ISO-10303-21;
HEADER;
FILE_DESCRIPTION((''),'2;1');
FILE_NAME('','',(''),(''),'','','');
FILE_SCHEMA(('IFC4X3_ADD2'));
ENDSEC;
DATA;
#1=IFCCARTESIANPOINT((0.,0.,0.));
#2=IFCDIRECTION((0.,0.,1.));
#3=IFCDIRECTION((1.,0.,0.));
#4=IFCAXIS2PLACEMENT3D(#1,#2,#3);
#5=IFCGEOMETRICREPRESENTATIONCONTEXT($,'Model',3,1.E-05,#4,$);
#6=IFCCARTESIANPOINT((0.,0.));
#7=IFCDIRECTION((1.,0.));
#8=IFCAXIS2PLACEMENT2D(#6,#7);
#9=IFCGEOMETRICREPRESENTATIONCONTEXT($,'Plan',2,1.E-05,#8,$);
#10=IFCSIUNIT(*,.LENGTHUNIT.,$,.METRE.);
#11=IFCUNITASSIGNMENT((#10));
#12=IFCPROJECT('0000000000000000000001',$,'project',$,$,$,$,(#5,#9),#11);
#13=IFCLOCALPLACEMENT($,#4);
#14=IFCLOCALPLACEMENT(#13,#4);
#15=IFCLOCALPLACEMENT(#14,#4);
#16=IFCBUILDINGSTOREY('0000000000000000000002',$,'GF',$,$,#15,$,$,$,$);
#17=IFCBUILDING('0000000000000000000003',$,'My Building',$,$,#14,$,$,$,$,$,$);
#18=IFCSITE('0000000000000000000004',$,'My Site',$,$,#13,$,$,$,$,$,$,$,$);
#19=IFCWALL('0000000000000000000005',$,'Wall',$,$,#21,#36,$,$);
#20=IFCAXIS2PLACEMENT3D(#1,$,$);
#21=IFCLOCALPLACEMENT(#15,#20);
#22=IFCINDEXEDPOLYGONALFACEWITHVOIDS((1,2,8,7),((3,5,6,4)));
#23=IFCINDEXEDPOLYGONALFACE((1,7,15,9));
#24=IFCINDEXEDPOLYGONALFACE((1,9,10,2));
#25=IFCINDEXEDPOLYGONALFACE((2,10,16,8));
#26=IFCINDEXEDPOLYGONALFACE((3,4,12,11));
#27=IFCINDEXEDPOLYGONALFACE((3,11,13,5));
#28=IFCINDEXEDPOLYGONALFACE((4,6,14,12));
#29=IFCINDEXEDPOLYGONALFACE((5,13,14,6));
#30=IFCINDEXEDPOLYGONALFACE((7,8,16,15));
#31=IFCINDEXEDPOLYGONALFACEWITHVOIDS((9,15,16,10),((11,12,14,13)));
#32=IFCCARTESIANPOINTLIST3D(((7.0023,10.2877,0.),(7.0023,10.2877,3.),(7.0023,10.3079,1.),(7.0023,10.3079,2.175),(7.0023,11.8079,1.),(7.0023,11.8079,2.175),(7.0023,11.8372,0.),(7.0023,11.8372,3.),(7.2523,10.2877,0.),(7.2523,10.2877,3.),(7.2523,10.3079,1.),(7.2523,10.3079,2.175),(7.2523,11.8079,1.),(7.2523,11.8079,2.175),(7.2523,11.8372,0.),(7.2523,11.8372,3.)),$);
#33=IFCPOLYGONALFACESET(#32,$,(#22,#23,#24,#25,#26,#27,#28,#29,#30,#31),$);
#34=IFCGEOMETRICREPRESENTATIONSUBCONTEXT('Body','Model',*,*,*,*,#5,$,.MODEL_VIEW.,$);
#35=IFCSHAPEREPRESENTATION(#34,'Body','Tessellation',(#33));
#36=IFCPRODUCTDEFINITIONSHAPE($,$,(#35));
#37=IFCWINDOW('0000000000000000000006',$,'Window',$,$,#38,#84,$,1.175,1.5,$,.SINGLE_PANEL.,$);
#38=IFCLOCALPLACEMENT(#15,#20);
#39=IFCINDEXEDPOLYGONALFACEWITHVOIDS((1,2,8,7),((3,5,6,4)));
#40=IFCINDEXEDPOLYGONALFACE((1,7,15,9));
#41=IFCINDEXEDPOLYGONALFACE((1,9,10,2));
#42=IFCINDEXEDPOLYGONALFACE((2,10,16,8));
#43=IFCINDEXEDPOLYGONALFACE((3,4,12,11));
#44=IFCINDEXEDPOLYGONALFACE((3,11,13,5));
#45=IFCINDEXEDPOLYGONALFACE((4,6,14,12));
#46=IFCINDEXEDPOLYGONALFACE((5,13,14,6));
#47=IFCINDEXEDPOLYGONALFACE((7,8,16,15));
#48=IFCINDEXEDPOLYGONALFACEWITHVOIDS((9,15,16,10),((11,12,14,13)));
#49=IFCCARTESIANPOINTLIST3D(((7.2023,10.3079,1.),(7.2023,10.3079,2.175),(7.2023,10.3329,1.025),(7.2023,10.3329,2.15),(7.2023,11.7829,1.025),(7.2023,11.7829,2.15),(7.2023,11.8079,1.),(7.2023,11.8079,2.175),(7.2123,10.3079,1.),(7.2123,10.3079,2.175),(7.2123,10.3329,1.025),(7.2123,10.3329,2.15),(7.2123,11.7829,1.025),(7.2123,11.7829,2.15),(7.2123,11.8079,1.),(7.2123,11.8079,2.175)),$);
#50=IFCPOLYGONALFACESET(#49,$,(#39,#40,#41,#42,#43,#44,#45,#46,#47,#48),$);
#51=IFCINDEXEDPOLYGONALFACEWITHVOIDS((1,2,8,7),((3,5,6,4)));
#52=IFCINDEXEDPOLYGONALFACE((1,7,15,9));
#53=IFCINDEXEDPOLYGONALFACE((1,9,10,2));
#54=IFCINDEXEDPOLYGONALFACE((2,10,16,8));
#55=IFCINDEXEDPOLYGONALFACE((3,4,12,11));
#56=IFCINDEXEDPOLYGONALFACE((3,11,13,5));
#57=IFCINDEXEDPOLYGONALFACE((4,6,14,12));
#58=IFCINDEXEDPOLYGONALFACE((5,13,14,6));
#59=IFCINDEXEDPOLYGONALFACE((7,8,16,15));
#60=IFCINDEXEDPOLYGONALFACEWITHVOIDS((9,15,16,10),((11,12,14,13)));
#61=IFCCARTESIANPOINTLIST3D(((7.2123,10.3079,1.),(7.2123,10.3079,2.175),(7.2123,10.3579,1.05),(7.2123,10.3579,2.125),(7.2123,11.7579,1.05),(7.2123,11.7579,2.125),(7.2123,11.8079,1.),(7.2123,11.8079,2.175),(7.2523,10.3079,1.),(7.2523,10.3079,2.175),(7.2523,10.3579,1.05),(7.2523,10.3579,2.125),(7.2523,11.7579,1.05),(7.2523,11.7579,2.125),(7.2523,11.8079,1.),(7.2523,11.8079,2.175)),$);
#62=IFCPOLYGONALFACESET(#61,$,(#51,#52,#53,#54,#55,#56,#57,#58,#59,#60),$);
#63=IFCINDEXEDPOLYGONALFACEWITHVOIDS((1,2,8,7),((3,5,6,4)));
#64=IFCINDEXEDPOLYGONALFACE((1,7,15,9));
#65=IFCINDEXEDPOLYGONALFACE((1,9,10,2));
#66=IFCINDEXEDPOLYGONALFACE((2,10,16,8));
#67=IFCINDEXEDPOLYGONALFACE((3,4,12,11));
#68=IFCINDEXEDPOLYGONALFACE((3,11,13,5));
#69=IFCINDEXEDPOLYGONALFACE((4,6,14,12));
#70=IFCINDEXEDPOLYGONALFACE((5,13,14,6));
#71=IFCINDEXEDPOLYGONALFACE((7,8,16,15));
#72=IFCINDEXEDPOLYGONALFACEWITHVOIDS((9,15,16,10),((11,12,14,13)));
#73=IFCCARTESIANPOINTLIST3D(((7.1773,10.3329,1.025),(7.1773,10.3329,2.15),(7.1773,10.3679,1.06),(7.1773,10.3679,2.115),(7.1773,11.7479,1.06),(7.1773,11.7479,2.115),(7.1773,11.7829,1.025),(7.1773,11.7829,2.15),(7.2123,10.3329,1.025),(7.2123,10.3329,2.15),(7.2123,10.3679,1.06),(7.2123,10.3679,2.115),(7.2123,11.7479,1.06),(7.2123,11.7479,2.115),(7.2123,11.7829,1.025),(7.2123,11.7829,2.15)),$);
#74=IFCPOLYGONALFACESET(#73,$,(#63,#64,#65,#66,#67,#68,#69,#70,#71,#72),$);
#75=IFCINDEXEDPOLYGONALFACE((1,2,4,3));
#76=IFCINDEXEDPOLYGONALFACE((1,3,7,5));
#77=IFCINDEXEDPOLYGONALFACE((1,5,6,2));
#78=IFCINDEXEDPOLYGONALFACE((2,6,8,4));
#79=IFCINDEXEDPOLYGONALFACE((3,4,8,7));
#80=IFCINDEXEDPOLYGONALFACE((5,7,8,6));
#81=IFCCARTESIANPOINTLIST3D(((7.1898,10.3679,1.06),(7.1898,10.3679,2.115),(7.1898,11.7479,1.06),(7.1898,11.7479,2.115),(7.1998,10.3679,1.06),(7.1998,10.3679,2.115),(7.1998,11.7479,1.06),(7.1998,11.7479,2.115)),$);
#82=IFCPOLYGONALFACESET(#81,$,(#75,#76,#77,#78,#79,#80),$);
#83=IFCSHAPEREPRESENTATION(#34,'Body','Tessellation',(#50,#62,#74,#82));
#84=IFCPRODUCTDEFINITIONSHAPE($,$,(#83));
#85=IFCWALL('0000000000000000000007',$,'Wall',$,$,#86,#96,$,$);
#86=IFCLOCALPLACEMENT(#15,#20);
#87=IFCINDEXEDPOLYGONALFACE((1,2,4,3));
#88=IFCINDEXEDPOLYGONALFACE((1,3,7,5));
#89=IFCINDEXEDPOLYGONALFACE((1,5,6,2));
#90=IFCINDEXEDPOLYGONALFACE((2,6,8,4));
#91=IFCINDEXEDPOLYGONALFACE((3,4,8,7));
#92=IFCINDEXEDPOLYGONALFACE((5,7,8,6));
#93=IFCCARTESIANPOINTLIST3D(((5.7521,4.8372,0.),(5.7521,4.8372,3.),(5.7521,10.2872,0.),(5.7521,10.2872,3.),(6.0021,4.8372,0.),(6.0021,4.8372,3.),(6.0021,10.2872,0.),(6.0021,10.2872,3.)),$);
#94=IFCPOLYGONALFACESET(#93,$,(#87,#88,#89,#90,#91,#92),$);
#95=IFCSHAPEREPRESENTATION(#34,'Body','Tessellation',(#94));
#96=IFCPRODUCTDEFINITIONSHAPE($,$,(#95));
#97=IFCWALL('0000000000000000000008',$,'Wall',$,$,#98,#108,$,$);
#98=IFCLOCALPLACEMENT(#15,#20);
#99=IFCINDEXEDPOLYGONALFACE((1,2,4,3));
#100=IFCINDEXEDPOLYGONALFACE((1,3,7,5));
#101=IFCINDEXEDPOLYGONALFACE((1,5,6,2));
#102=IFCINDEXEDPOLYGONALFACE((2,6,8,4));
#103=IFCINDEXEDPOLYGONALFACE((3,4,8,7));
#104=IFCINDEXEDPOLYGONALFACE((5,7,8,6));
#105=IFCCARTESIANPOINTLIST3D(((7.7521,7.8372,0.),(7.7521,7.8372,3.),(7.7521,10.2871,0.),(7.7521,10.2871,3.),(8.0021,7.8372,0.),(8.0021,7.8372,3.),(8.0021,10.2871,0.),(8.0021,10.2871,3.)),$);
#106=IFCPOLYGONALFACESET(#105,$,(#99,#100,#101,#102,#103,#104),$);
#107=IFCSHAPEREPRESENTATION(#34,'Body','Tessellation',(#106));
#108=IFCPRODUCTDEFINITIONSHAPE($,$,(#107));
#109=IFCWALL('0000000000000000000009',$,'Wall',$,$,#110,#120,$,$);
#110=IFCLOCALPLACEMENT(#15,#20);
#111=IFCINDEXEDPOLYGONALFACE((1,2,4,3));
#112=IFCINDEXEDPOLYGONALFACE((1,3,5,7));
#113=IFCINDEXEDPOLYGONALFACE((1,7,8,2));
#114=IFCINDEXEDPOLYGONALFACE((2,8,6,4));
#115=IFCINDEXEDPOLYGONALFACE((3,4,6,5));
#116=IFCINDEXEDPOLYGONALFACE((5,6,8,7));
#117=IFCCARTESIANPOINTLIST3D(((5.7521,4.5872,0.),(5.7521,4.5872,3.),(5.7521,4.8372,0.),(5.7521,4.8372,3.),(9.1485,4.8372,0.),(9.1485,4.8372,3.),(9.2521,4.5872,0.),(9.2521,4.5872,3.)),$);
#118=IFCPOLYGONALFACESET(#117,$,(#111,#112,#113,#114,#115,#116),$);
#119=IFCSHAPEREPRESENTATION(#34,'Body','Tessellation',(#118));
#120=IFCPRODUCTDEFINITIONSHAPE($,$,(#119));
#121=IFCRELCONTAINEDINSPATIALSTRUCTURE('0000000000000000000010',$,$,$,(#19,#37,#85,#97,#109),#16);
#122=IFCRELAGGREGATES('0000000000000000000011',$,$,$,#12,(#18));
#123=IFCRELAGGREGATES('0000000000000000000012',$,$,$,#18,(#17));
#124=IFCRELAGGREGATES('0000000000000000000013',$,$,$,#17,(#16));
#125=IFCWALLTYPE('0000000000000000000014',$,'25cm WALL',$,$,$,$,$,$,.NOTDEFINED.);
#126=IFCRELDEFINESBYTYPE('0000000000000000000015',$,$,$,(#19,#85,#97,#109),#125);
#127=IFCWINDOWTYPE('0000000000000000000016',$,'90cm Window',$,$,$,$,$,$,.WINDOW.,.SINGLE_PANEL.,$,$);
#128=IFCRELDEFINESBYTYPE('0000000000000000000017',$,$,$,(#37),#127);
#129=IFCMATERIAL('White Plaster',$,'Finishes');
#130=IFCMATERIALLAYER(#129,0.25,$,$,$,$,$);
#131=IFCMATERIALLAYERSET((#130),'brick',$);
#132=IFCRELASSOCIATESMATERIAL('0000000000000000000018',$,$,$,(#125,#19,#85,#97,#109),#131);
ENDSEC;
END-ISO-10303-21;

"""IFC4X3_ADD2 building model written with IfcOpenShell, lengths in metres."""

from ifc_helpers import new_model, entity, si_unit, frame, origin_with_axes, origin_2d_with_axis, place, context, subcontext, project, spatial, line, indexed_curve, outline, extrude, shape, source, transform, mapped, material, layer, layer_set, layer_usage, type_object, type_shapes, element, fill, save


model = new_model("IFC4X3_ADD2")

# Units and contexts
model_context = context("Model", 3, precision=1e-05, world=origin_with_axes())
plan_context = context("Plan", 2, precision=1e-05, world=origin_2d_with_axis())
body_context_1 = subcontext(model_context, "Body", "Model", "MODEL_VIEW")
body_context_2 = subcontext(plan_context, "Body", "Plan", "PLAN_VIEW")
ifc_project = project(units=[si_unit("LENGTHUNIT", "METRE")], contexts=[model_context, plan_context])

# Site, building, storey
site_placement = place(None, origin_with_axes())
site = spatial("IfcSite", under=ifc_project, at=site_placement, Name="My Site")
building_placement = place(site_placement, origin_with_axes())
building = spatial("IfcBuilding", under=site, at=building_placement, Name="My Building")
storey_placement = place(building_placement, origin_with_axes())
storey = spatial("IfcBuildingStorey", under=building, at=storey_placement, Name="GF")

# Shared definitions
ifc_material_1 = material(Name="White Plaster", Category="Finishes")

# Shared definitions
ifc_layer_1 = layer(ifc_material_1, 0.25)
ifc_layer_set_1 = layer_set([ifc_layer_1], Name="brick")
wall_type_1 = type_object("IfcWallType", Name="25cm WALL", PredefinedType="NOTDEFINED", material=ifc_layer_set_1)

# Wall, opening, window
ifc_layer_usage_1 = layer_usage(ifc_layer_set_1, "AXIS2", "POSITIVE", 0.0)
wall_1_placement = place(storey_placement, frame((7.0023, 11.8372, 0.0), z_axis=(0.0, 0.0, 1.0), x_axis=(0.0, -1.0, 0.0)))
wall_1 = element("IfcWall", 1, at=wall_1_placement, inside=storey, type_object=wall_type_1, material=ifc_layer_usage_1, Name="Wall", context=body_context_1, shape_type="SweptSolid", body=[
    extrude(outline(indexed_curve([(0.0, 0.0), (0.0, 0.25), (1.5495, 0.25), (1.5495, 0.0)], segments=[line(1, 2, 3, 4, 1)])), origin_with_axes(), (0.0, 0.0, 1.0), 3.0),
])
shared_shape_1 = source(origin_with_axes(), body_context_1, "Body", "SweptSolid", [
    extrude(outline(indexed_curve([(0.0, 0.0), (1.5, 0.0), (1.5, 1.175), (0.0, 1.175)], segments=[line(1, 2, 3, 4, 1)])), frame((0.0, -0.6, 0.0), z_axis=(0.0, -1.0, 0.0), x_axis=(1.0, 0.0, 0.0)), (0.0, 0.0, -1.0), 1.2),
])
opening_1_placement = place(wall_1_placement, frame((1.5293, 0.3, 1.0), z_axis=(0.0, 0.0, 1.0), x_axis=(-1.0, 0.0, 0.0)))
opening_1 = element("IfcOpeningElement", 2, at=opening_1_placement, cuts=wall_1, PredefinedType="OPENING", context=body_context_1, shape_type="MappedRepresentation", body=[
    mapped(shared_shape_1, transform((0.0, 0.0, 0.0), x_axis=(1.0, 0.0, 0.0), y_axis=(0.0, 1.0, 0.0), z_axis=(0.0, 0.0, 1.0), scale=1.0)),
])
window_type_1 = type_object("IfcWindowType", Name="90cm Window", PartitioningType="SINGLE_PANEL", PredefinedType="WINDOW")
shared_shape_2 = source(origin_with_axes(), body_context_1, "Body", "SweptSolid", [
    extrude(outline(indexed_curve([(0.0, 0.0), (1.5, 0.0), (1.5, 1.175), (0.0, 1.175)], segments=[line(1, 2, 3, 4, 1)]), holes=[indexed_curve([(0.025, 0.025), (1.475, 0.025), (1.475, 1.15), (0.025, 1.15)], segments=[line(1, 2, 3, 4, 1)])]), frame((0.0, 0.09, 0.0), z_axis=(0.0, -1.0, 0.0), x_axis=(1.0, 0.0, 0.0)), (0.0, 0.0, -1.0), 0.01),
    extrude(outline(indexed_curve([(0.0, 0.0), (1.5, 0.0), (1.5, 1.175), (0.0, 1.175)], segments=[line(1, 2, 3, 4, 1)]), holes=[indexed_curve([(0.05, 0.05), (1.45, 0.05), (1.45, 1.125), (0.05, 1.125)], segments=[line(1, 2, 3, 4, 1)])]), frame((0.0, 0.05, 0.0), z_axis=(0.0, -1.0, 0.0), x_axis=(1.0, 0.0, 0.0)), (0.0, 0.0, -1.0), 0.04),
    extrude(outline(indexed_curve([(0.0, 0.0), (1.45, 0.0), (1.45, 1.125), (0.0, 1.125)], segments=[line(1, 2, 3, 4, 1)]), holes=[indexed_curve([(0.035, 0.035), (1.415, 0.035), (1.415, 1.09), (0.035, 1.09)], segments=[line(1, 2, 3, 4, 1)])]), frame((0.025, 0.09, 0.025), z_axis=(0.0, -1.0, 0.0), x_axis=(1.0, 0.0, 0.0)), (0.0, 0.0, -1.0), 0.035),
    extrude(outline(indexed_curve([(0.035, 0.035), (1.415, 0.035), (1.415, 1.09), (0.035, 1.09)], segments=[line(1, 2, 3, 4, 1)])), frame((0.025, 0.1025, 0.025), z_axis=(0.0, -1.0, 0.0), x_axis=(1.0, 0.0, 0.0)), (0.0, 0.0, -1.0), 0.01),
])
shared_shape_3 = source(origin_with_axes(), body_context_2, "Body", "Curve2D", [
    entity("IfcIndexedPolyCurve", entity("IfcCartesianPointList2D", [[0.05, 0.05], [1.45, 0.05]])),
    entity("IfcIndexedPolyCurve", entity("IfcCartesianPointList2D", [[0.0, 0.1], [0.025, 0.1], [0.025, 0.09], [0.05, 0.09], [0.05, 0.05], [0.0, 0.05]]), [entity("IfcLineIndex", [1, 2, 3, 4, 5, 6, 1])]),
    entity("IfcIndexedPolyCurve", entity("IfcCartesianPointList2D", [[1.5, 0.1], [1.475, 0.1], [1.475, 0.09], [1.45, 0.09], [1.45, 0.05], [1.5, 0.05]]), [entity("IfcLineIndex", [1, 2, 3, 4, 5, 6, 1])]),
    entity("IfcIndexedPolyCurve", entity("IfcCartesianPointList2D", [[0.025, 0.09], [0.06, 0.09], [0.06, 0.125], [0.025, 0.125]]), [entity("IfcLineIndex", [1, 2, 3, 4, 1])]),
    entity("IfcIndexedPolyCurve", entity("IfcCartesianPointList2D", [[1.475, 0.09], [1.44, 0.09], [1.44, 0.125], [1.475, 0.125]]), [entity("IfcLineIndex", [1, 2, 3, 4, 1])]),
    entity("IfcIndexedPolyCurve", entity("IfcCartesianPointList2D", [[0.06, 0.09], [1.44, 0.09]])),
    entity("IfcIndexedPolyCurve", entity("IfcCartesianPointList2D", [[0.06, 0.125], [1.44, 0.125]])),
    entity("IfcIndexedPolyCurve", entity("IfcCartesianPointList2D", [[0.06, 0.1075], [1.44, 0.1075]])),
])
type_shapes(window_type_1, [shared_shape_2, shared_shape_3])
window_1_placement = place(opening_1_placement, origin_with_axes())
window_1 = element("IfcWindow", 3, at=window_1_placement, inside=storey, type_object=window_type_1, Name="Window", OverallHeight=1.175, OverallWidth=1.5, PartitioningType="SINGLE_PANEL", shapes=[
    shape(body_context_1, "Body", "MappedRepresentation", [mapped(shared_shape_2, transform((0.0, 0.0, 0.0), x_axis=(1.0, 0.0, 0.0), y_axis=(0.0, 1.0, 0.0), z_axis=(0.0, 0.0, 1.0), scale=1.0))]),
    shape(body_context_2, "Body", "MappedRepresentation", [mapped(shared_shape_3, transform((0.0, 0.0, 0.0), x_axis=(1.0, 0.0, 0.0), y_axis=(0.0, 1.0, 0.0), z_axis=(0.0, 0.0, 1.0), scale=1.0))]),
])
fill(opening_1, window_1)

# Walls
ifc_layer_usage_2 = layer_usage(ifc_layer_set_1, "AXIS2", "POSITIVE", 0.0)
wall_2_placement = place(storey_placement, frame((5.7521, 10.2872, 0.0), z_axis=(0.0, 0.0, 1.0), x_axis=(0.0, -1.0, 0.0)))
element("IfcWall", 4, at=wall_2_placement, inside=storey, type_object=wall_type_1, material=ifc_layer_usage_2, Name="Wall", context=body_context_1, shape_type="SweptSolid", body=[
    extrude(outline(indexed_curve([(0.0, 0.0), (0.0, 0.25), (5.45, 0.25), (5.45, 0.0)], segments=[line(1, 2, 3, 4, 1)])), origin_with_axes(), (0.0, 0.0, 1.0), 3.0),
])
ifc_layer_usage_3 = layer_usage(ifc_layer_set_1, "AXIS2", "POSITIVE", 0.0)
wall_3_placement = place(storey_placement, frame((7.7521, 10.2871, 0.0), z_axis=(0.0, 0.0, 1.0), x_axis=(0.0, -1.0, 0.0)))
element("IfcWall", 5, at=wall_3_placement, inside=storey, type_object=wall_type_1, material=ifc_layer_usage_3, Name="Wall", context=body_context_1, shape_type="SweptSolid", body=[
    extrude(outline(indexed_curve([(0.0, 0.0), (0.0, 0.25), (2.45, 0.25), (2.45, 0.0)], segments=[line(1, 2, 3, 4, 1)])), origin_with_axes(), (0.0, 0.0, 1.0), 3.0),
])
ifc_layer_usage_4 = layer_usage(ifc_layer_set_1, "AXIS2", "POSITIVE", 0.0)
wall_4_placement = place(storey_placement, frame((5.7521, 4.5872, 0.0), z_axis=(0.0, 0.0, 1.0), x_axis=(1.0, 0.0, 0.0)))
element("IfcWall", 6, at=wall_4_placement, inside=storey, type_object=wall_type_1, material=ifc_layer_usage_4, Name="Wall", context=body_context_1, shape_type="SweptSolid", body=[
    extrude(outline(indexed_curve([(0.0, 0.0), (0.0, 0.25), (3.3964, 0.25), (3.5, 0.0)], segments=[line(1, 2, 3, 4, 1)])), origin_with_axes(), (0.0, 0.0, 1.0), 3.0),
])

save(model, "model.ifc")
